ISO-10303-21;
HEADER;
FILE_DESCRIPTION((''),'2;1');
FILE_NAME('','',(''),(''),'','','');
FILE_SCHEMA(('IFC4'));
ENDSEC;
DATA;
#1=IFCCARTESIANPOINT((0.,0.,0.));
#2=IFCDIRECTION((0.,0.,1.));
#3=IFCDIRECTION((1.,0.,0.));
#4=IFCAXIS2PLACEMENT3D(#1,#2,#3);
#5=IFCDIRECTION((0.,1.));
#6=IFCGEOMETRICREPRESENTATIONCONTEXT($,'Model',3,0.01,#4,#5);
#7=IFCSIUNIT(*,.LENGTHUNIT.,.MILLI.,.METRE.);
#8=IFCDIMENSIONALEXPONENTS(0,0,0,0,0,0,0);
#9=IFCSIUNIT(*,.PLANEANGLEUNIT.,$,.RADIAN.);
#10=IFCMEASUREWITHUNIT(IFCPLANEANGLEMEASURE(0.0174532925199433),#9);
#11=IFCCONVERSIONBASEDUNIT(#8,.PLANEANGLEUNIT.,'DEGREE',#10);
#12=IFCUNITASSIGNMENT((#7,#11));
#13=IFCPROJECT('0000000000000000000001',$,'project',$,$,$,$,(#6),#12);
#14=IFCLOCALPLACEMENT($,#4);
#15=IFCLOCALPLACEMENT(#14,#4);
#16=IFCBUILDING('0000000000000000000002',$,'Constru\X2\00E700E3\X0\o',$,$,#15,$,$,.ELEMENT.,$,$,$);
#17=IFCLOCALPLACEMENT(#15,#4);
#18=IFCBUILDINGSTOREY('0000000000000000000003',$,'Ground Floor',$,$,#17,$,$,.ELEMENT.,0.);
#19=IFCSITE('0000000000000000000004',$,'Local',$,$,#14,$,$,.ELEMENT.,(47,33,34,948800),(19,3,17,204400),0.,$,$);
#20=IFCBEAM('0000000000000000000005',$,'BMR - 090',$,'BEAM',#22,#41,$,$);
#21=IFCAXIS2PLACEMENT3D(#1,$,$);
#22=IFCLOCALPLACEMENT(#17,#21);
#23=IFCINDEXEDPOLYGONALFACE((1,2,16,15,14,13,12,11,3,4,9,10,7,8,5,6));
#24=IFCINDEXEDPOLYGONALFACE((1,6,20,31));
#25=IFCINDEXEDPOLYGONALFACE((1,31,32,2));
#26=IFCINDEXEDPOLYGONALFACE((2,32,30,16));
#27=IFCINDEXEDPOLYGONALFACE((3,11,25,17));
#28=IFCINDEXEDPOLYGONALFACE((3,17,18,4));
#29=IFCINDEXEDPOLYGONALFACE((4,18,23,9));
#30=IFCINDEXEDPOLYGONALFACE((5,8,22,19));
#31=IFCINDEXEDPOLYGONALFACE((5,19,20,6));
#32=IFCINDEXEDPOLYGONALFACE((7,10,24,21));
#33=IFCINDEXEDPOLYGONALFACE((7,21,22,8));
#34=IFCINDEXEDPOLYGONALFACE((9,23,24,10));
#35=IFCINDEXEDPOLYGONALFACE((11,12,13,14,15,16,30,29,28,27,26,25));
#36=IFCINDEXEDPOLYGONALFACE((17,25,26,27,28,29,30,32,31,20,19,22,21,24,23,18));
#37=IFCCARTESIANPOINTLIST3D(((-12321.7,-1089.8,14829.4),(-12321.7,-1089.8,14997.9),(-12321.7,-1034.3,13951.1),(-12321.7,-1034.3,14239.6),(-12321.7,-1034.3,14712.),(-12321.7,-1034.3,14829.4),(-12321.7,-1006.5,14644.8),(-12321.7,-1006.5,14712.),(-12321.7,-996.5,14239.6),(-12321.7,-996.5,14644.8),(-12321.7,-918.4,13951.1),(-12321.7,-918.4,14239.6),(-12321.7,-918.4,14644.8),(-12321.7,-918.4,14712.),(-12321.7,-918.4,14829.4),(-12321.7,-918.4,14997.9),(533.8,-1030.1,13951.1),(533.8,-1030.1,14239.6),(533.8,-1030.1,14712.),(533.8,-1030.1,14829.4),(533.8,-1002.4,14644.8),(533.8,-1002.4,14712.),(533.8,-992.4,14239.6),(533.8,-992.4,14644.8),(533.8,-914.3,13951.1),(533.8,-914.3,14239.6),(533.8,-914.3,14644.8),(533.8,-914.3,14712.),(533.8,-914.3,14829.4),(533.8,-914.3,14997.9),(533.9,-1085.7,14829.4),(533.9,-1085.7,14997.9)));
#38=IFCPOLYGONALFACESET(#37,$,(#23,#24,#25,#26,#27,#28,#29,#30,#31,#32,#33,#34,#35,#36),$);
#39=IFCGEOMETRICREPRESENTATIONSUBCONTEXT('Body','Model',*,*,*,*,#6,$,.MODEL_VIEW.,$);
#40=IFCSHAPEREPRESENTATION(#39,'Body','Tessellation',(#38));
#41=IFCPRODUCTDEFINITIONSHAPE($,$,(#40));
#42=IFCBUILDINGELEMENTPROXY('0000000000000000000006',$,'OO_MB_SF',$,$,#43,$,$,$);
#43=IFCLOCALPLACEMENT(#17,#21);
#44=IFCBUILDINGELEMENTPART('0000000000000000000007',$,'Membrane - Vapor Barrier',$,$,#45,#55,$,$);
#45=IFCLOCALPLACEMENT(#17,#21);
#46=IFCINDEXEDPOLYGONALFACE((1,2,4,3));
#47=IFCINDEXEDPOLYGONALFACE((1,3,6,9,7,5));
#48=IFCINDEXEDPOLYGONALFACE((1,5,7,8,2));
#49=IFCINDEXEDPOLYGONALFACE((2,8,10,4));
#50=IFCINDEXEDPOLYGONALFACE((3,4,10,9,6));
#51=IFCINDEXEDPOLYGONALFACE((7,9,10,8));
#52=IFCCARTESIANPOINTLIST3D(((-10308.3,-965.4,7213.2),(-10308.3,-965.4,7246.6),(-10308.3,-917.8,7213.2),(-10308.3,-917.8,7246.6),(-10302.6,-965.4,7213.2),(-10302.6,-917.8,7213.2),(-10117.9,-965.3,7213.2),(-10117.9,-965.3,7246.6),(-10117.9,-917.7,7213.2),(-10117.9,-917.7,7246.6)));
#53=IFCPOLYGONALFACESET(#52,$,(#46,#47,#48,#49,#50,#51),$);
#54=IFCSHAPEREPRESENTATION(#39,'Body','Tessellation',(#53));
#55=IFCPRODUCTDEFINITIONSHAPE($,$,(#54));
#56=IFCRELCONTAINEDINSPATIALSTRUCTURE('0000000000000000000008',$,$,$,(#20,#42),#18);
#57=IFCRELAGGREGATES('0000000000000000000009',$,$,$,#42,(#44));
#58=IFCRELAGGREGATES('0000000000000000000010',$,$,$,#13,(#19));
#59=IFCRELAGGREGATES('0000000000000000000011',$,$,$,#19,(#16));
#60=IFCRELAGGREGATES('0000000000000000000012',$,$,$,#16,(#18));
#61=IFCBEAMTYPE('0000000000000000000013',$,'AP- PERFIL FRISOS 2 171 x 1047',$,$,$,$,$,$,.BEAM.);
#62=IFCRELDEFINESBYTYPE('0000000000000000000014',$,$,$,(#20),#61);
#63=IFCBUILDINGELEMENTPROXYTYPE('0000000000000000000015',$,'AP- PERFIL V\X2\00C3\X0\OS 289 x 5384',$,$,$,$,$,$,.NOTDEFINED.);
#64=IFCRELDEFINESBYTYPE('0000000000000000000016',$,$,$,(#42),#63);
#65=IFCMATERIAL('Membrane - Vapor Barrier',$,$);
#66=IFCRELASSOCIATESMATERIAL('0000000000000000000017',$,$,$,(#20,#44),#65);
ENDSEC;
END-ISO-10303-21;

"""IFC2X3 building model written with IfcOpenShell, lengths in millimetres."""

from ifc_helpers import new_model, entity, si_unit, converted_unit, direction, frame, origin_with_axes, place, context, subcontext, project, spatial, polyline, outline, extrude, material, type_object, element, aggregate, save


model = new_model("IFC2X3")

# Units and contexts
model_context = context("Model", 3, precision=0.01, world=origin_with_axes(), true_north=direction((0.0, 1.0)))
body_context = subcontext(model_context, "Body", "Model", "MODEL_VIEW")
ifc_project = project(units=[si_unit("LENGTHUNIT", "METRE", prefix="MILLI"), converted_unit("PLANEANGLEUNIT", "DEGREE", entity("IfcPlaneAngleMeasure", 0.0174532925199433), si_unit("PLANEANGLEUNIT", "RADIAN"), dimensions=[0, 0, 0, 0, 0, 0, 0])], contexts=[model_context])

# Site, building, storey
site_placement = place(None, origin_with_axes())
site = spatial("IfcSite", under=ifc_project, at=site_placement, Name="Local", CompositionType="ELEMENT", RefLatitude=(47, 33, 34, 948800), RefLongitude=(19, 3, 17, 204400), RefElevation=0.0)
building_placement = place(site_placement, origin_with_axes())
building = spatial("IfcBuilding", under=site, at=building_placement, Name="Construção", CompositionType="ELEMENT")
storey_placement = place(building_placement, origin_with_axes())
storey = spatial("IfcBuildingStorey", under=building, at=storey_placement, Name="Ground Floor", CompositionType="ELEMENT", Elevation=0.0)

# Beam
ifc_material = material(Name="Membrane - Vapor Barrier")
beam_type = type_object("IfcBeamType", Name="AP- PERFIL FRISOS 2 171 x 1047", PredefinedType="BEAM")
beam_placement = place(storey_placement, frame((-12321.7, -918.4, 13951.1), z_axis=(0.0, 0.0, 1.0), x_axis=(0.000322, -1.0, 0.0)))
element("IfcBeam", 1, at=beam_placement, inside=storey, type_object=beam_type, material=ifc_material, Name="BMR - 090", ObjectType="BEAM", context=body_context, shape_type="SweptSolid", body=[
    extrude(outline(polyline([(0.0, 288.6), (0.0, 0.0), (115.9, 0.0), (115.9, 288.6), (78.1, 288.6), (78.1, 693.7), (88.1, 693.7), (88.1, 760.9), (115.9, 760.9), (115.9, 878.3), (171.4, 878.3), (171.4, 1046.8), (0.0, 1046.8), (0.0, 878.3), (0.0, 760.9), (0.0, 693.7), (0.0, 288.6)])), frame((0.0, 12855.5, 0.0), z_axis=(0.0, -1.0, 0.0), x_axis=(1.0, 0.0, 0.0)), (0.0, 0.0, 1.0), 12855.5),
])

# Building element proxy, building element part
building_element_proxy_type = type_object("IfcBuildingElementProxyType", Name="AP- PERFIL VÃOS 289 x 5384", PredefinedType="NOTDEFINED")
proxy_1_placement = place(storey_placement, frame((-10117.9, -917.7, 7246.6), z_axis=(0.0, 0.0, 1.0), x_axis=(-1.0, -0.000322, 0.0)))
proxy_1 = element("IfcBuildingElementProxy", 2, at=proxy_1_placement, inside=storey, type_object=building_element_proxy_type, Name="OO_MB_SF")
building_element_part_1_placement = place(proxy_1_placement, origin_with_axes())
building_element_part_1 = element("IfcBuildingElementPart", 3, at=building_element_part_1_placement, material=ifc_material, Name="Membrane - Vapor Barrier", context=body_context, shape_type="SweptSolid", body=[
    extrude(outline(polyline([(190.4, 0.0), (0.0, 0.0), (0.0, -33.3), (184.7, -33.3), (190.4, -33.3), (190.4, 0.0)])), frame((0.0, 47.6, 0.0), z_axis=(0.0, -1.0, 0.0), x_axis=(1.0, 0.0, 0.0)), (0.0, 0.0, 1.0), 47.6),
])
aggregate(proxy_1, [building_element_part_1])

save(model, "model.ifc")
